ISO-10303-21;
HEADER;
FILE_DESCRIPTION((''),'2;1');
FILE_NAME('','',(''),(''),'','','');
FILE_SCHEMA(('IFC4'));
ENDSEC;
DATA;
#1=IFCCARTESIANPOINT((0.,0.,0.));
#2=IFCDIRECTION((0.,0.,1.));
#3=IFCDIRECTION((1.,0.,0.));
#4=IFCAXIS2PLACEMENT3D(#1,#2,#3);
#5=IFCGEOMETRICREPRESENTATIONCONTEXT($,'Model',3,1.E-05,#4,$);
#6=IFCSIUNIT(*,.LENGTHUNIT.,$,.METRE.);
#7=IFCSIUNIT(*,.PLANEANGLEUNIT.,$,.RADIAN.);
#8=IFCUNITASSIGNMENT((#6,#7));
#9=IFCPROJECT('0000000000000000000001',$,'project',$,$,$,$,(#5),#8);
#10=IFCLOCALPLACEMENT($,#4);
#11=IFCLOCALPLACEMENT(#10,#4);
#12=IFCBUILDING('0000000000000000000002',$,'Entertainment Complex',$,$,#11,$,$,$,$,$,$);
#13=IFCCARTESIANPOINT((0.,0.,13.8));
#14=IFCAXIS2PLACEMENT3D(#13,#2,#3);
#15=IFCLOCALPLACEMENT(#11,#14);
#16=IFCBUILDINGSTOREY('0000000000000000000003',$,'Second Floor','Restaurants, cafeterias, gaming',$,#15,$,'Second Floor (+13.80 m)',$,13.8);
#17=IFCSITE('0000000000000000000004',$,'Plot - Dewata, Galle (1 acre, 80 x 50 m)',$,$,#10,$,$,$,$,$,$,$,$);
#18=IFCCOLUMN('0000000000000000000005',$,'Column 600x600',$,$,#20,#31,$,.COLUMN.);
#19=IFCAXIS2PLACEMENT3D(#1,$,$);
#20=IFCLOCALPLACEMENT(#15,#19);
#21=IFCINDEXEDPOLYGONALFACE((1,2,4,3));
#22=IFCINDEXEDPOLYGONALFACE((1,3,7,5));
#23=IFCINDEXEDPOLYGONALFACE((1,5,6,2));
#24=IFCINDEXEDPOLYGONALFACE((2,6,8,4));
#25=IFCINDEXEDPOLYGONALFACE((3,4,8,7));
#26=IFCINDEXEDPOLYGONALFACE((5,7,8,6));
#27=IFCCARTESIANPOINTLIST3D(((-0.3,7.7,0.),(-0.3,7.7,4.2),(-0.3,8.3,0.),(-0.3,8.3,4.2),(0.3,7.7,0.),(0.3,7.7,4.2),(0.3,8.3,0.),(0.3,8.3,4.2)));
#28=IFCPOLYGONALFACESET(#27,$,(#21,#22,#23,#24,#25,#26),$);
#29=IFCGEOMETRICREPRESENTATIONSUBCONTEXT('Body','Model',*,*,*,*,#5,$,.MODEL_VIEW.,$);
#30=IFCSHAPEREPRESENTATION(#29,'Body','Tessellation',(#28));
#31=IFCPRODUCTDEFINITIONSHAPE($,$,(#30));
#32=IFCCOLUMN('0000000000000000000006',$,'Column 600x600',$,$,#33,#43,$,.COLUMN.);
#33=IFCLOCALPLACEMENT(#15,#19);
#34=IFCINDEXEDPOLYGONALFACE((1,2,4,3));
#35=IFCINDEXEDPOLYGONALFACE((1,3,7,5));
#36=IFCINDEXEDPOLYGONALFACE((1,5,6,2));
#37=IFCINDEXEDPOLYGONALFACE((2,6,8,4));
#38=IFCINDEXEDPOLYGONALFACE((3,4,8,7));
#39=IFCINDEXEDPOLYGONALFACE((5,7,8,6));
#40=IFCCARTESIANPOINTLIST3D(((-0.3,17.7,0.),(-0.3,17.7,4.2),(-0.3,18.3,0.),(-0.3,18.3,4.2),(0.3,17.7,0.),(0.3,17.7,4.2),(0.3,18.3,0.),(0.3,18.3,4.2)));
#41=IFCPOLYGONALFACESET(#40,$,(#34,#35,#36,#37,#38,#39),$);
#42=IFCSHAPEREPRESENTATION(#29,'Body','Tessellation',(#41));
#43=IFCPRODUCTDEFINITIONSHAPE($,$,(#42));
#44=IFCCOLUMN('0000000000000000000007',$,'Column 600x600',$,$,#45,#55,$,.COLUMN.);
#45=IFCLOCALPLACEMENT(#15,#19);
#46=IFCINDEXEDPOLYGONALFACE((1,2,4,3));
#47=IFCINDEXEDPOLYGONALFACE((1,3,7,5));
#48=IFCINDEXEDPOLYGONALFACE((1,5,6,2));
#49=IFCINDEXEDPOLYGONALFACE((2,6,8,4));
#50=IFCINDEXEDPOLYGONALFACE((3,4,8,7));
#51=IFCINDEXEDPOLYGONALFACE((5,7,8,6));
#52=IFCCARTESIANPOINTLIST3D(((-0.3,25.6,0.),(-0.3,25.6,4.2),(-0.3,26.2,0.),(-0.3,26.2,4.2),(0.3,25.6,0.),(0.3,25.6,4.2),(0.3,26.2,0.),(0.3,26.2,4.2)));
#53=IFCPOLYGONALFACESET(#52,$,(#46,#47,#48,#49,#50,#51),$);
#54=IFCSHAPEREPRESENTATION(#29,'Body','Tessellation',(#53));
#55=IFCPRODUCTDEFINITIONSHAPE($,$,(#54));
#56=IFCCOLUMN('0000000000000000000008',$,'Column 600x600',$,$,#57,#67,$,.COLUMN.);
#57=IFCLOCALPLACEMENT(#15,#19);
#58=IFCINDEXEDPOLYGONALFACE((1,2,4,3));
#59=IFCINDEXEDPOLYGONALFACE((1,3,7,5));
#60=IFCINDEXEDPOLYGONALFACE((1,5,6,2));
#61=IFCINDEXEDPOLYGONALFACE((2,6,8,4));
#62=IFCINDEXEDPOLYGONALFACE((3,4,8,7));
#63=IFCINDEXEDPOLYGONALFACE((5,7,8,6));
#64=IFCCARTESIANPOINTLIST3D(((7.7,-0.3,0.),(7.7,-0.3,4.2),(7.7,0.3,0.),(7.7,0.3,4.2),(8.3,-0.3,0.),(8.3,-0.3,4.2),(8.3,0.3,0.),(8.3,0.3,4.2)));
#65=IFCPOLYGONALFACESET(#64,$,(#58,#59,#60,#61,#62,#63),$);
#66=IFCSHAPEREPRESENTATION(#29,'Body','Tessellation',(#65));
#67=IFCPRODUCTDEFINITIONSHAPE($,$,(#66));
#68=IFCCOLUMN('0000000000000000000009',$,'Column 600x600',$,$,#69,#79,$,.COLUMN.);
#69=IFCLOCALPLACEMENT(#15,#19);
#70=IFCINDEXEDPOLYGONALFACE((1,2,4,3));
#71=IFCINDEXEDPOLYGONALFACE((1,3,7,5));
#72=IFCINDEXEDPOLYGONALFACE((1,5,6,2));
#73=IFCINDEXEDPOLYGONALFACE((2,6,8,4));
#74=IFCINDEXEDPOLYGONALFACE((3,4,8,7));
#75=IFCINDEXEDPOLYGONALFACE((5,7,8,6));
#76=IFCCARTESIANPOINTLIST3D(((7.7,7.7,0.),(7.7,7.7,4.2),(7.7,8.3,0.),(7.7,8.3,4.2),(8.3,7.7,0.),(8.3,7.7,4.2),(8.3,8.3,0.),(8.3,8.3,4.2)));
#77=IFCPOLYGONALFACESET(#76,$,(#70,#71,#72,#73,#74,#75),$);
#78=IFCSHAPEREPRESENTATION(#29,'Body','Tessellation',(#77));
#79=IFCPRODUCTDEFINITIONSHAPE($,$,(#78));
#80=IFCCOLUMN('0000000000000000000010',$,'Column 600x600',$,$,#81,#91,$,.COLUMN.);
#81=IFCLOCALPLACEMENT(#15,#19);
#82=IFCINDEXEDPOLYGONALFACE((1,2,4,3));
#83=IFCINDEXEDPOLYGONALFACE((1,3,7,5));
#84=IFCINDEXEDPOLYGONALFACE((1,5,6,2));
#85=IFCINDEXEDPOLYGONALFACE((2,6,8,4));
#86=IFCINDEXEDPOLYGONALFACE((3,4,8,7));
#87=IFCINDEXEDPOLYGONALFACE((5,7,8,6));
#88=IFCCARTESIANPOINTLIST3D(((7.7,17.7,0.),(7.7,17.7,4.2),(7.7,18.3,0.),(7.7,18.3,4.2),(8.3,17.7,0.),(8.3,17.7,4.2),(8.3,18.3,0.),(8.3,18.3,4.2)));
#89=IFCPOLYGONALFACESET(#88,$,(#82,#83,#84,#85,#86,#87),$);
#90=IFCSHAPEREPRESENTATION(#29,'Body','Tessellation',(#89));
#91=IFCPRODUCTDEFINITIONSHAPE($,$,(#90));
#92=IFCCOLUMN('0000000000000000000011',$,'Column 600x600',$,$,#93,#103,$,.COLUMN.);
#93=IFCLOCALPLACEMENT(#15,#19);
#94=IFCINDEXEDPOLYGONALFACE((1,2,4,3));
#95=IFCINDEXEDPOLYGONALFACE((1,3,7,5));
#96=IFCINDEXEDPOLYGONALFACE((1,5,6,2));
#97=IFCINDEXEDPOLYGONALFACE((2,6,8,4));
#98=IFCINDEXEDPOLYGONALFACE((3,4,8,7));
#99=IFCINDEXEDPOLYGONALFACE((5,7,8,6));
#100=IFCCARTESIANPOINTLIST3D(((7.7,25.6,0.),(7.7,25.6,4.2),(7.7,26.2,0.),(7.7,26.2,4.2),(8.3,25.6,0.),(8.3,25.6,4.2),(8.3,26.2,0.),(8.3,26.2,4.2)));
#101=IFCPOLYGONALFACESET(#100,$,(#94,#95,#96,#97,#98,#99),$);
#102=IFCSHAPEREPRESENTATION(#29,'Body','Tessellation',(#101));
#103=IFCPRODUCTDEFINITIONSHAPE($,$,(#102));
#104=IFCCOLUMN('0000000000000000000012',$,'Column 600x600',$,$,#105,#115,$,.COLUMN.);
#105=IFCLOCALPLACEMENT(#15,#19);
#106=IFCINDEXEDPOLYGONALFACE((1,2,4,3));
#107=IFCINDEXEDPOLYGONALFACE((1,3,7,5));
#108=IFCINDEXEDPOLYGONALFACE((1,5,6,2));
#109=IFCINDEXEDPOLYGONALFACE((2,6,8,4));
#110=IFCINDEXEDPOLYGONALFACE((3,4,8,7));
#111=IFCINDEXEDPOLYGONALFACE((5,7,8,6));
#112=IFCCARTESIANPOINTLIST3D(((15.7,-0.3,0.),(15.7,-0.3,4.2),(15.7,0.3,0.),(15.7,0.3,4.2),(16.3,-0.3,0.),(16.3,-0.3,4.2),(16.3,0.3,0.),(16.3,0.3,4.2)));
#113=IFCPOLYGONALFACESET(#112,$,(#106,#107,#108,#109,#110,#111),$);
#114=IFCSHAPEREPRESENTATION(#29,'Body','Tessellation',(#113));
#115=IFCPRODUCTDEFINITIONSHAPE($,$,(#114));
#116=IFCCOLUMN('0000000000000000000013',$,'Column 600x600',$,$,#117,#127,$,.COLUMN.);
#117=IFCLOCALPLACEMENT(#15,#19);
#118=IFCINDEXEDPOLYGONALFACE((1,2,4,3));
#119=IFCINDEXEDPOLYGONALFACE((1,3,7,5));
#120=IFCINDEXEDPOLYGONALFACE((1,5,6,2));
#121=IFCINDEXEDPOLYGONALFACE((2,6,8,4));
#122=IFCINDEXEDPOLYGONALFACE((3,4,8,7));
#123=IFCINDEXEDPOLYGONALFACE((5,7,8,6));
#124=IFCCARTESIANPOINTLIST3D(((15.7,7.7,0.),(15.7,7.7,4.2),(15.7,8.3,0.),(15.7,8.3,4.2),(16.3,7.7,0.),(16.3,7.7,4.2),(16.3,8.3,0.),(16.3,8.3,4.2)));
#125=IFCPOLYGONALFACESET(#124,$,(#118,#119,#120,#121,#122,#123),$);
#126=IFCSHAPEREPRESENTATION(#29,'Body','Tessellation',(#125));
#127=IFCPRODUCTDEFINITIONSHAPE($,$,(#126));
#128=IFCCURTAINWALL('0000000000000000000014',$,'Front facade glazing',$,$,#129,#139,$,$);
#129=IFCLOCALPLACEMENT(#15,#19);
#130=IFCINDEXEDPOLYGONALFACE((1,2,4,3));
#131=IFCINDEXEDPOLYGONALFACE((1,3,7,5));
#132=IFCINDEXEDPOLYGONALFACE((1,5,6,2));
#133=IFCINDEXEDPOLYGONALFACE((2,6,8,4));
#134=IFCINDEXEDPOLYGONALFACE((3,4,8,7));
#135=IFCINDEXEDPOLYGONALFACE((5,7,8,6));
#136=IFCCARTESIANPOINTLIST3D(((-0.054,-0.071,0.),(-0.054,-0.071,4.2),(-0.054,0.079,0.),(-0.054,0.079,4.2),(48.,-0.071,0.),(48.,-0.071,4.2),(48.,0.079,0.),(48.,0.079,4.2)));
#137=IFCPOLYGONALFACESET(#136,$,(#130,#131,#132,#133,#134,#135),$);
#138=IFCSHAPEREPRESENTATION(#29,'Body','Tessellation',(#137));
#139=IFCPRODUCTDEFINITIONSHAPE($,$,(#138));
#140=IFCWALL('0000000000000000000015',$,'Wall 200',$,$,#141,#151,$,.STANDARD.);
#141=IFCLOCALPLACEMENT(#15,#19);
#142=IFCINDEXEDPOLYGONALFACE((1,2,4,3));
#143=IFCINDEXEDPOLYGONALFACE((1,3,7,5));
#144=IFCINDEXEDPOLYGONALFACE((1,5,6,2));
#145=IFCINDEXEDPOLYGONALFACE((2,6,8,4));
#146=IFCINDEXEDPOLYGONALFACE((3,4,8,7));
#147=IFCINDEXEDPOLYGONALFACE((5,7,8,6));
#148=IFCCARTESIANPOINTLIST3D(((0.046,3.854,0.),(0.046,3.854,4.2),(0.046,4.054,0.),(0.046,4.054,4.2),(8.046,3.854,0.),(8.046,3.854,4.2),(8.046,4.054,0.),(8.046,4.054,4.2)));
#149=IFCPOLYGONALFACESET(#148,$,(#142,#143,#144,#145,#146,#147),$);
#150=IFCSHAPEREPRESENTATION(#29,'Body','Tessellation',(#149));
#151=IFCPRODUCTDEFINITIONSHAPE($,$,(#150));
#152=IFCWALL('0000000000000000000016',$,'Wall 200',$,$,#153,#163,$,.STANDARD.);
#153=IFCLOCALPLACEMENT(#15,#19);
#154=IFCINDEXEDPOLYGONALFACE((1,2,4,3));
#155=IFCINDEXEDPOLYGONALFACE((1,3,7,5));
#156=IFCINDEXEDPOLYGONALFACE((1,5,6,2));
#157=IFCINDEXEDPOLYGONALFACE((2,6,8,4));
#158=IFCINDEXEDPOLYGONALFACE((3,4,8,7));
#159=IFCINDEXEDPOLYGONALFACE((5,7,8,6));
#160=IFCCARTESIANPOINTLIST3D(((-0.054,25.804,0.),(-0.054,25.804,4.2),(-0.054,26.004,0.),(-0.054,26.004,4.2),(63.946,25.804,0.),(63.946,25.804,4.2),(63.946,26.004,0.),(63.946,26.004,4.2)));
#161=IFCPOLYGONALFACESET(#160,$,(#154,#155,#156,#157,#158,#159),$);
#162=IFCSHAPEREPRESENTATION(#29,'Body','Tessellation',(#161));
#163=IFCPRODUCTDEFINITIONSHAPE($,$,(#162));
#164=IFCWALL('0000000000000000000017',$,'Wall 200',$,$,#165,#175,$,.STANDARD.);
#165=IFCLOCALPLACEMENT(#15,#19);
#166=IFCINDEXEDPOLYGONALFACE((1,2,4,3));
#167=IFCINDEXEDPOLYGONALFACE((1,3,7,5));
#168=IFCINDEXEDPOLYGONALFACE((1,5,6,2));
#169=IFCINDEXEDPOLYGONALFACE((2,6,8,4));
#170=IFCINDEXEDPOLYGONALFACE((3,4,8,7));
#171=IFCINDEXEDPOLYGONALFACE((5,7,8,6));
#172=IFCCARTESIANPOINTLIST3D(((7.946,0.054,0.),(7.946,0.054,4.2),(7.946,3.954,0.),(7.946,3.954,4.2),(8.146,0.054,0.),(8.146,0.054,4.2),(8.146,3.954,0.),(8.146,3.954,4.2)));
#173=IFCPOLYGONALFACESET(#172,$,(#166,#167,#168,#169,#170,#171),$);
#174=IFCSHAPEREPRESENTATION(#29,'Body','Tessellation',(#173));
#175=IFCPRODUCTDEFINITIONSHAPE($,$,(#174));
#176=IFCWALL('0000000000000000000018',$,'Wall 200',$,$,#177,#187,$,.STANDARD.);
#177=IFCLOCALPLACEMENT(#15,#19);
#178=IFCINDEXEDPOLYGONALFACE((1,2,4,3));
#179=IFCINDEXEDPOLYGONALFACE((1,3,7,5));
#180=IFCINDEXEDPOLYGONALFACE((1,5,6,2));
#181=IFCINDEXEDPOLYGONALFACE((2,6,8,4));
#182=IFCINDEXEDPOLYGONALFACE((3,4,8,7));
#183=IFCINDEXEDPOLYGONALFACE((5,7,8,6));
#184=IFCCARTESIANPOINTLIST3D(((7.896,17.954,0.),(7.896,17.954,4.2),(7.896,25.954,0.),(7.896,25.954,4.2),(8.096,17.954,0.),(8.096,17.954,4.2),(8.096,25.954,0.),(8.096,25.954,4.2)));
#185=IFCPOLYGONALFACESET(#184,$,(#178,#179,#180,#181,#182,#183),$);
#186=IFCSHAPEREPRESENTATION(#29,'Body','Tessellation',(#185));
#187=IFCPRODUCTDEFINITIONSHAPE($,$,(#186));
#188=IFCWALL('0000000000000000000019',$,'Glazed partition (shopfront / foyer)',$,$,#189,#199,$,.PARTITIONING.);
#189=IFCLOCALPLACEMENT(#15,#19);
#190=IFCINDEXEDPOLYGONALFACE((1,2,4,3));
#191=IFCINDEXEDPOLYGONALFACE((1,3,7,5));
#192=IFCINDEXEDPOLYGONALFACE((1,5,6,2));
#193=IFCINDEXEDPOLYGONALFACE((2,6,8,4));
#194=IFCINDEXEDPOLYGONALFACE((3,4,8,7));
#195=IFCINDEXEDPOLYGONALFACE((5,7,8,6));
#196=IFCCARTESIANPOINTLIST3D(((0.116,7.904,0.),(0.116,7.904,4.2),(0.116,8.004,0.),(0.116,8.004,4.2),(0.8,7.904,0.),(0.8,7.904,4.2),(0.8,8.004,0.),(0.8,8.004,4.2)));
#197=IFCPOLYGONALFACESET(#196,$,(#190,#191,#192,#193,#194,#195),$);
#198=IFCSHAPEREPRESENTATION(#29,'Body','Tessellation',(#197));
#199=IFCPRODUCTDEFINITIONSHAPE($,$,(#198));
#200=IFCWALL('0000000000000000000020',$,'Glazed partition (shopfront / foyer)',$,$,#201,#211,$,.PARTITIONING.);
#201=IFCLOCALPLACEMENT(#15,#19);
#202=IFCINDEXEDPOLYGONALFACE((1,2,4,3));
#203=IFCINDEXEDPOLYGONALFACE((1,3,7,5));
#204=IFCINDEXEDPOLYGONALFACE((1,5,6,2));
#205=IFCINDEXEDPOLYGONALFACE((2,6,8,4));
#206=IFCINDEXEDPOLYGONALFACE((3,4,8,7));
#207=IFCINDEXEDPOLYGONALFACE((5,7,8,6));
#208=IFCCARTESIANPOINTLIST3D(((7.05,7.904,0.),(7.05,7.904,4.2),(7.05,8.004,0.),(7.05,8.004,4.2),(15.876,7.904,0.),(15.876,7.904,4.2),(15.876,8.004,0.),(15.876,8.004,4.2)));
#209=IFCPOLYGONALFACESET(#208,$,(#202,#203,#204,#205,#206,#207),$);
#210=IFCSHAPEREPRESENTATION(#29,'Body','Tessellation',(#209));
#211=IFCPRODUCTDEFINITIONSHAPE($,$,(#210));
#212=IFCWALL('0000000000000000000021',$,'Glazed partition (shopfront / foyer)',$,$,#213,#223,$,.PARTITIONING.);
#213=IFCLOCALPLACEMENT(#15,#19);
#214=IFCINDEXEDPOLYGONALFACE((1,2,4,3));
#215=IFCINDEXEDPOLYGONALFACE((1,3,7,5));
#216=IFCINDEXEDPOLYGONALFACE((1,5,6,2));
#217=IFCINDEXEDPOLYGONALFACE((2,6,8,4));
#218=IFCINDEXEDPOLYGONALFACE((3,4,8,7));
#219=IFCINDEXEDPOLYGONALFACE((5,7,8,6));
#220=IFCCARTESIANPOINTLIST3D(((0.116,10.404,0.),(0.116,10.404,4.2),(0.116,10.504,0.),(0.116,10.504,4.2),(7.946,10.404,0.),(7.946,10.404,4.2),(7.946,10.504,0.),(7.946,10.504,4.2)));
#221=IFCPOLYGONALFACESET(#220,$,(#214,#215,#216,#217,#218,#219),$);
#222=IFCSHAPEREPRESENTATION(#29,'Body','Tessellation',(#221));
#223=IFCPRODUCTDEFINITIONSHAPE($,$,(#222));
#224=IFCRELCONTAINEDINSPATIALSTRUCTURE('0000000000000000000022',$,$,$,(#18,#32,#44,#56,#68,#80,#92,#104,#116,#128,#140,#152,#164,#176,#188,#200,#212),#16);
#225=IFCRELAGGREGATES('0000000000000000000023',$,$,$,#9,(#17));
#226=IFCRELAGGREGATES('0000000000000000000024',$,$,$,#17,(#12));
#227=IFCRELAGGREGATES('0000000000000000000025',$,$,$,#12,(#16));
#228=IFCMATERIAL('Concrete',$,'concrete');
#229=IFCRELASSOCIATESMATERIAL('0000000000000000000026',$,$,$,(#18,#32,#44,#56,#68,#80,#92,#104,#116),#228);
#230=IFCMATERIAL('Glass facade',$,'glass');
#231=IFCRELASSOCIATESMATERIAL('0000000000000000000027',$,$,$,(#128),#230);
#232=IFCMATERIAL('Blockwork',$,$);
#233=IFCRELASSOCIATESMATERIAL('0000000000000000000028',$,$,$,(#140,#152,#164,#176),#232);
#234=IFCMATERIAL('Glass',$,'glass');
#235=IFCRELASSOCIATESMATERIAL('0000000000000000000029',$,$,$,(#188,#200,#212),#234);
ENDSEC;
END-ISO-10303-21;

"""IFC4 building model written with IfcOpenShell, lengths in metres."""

from ifc_helpers import new_model, si_unit, frame, origin_with_axes, place, context, subcontext, project, spatial, polyline, outline, extrude, material, element, save


model = new_model("IFC4")

# Units and contexts
model_context = context("Model", 3, precision=1e-05, world=origin_with_axes())
body_context = subcontext(model_context, "Body", "Model", "MODEL_VIEW")
ifc_project = project(units=[si_unit("LENGTHUNIT", "METRE"), si_unit("PLANEANGLEUNIT", "RADIAN")], contexts=[model_context])

# Site, building, storey
site_placement = place(None, origin_with_axes())
site = spatial("IfcSite", under=ifc_project, at=site_placement, Name="Plot - Dewata, Galle (1 acre, 80 x 50 m)")
building_placement = place(site_placement, origin_with_axes())
building = spatial("IfcBuilding", under=site, at=building_placement, Name="Entertainment Complex")
storey_placement = place(building_placement, frame((0.0, 0.0, 13.8), z_axis=(0.0, 0.0, 1.0), x_axis=(1.0, 0.0, 0.0)))
storey = spatial("IfcBuildingStorey", under=building, at=storey_placement, Name="Second Floor", Description="Restaurants, cafeterias, gaming", LongName="Second Floor (+13.80 m)", Elevation=13.8)

# Columns
ifc_material_1 = material(Name="Concrete", Category="concrete")
for number, where, z_axis, x_axis, name in (
    (1, (0.0, 8.0, 0.0), (0.0, 0.0, 1.0), (1.0, 0.0, 0.0), "Column 600x600"),
    (2, (0.0, 18.0, 0.0), (0.0, 0.0, 1.0), (1.0, 0.0, 0.0), "Column 600x600"),
    (3, (0.0, 25.9, 0.0), (0.0, 0.0, 1.0), (1.0, 0.0, 0.0), "Column 600x600"),
    (4, (8.0, 0.0, 0.0), (0.0, 0.0, 1.0), (1.0, 0.0, 0.0), "Column 600x600"),
    (5, (8.0, 8.0, 0.0), (0.0, 0.0, 1.0), (1.0, 0.0, 0.0), "Column 600x600"),
    (6, (8.0, 18.0, 0.0), (0.0, 0.0, 1.0), (1.0, 0.0, 0.0), "Column 600x600"),
    (7, (8.0, 25.9, 0.0), (0.0, 0.0, 1.0), (1.0, 0.0, 0.0), "Column 600x600"),
    (8, (16.0, 0.0, 0.0), (0.0, 0.0, 1.0), (1.0, 0.0, 0.0), "Column 600x600"),
    (9, (16.0, 8.0, 0.0), (0.0, 0.0, 1.0), (1.0, 0.0, 0.0), "Column 600x600"),
):
    element("IfcColumn", number, at=place(storey_placement, frame(where, z_axis=z_axis, x_axis=x_axis)), inside=storey, material=ifc_material_1, Name=name, PredefinedType="COLUMN", context=body_context, shape_type="SweptSolid", body=[
        extrude(outline(polyline([(-0.3, -0.3), (0.3, -0.3), (0.3, 0.3), (-0.3, 0.3), (-0.3, -0.3)])), origin_with_axes(), (0.0, 0.0, 1.0), 4.2),
    ])

# Curtain wall
ifc_material_2 = material(Name="Glass facade", Category="glass")
curtain_wall_placement = place(storey_placement, frame((-0.054, 0.004, 0.0), z_axis=(0.0, 0.0, 1.0), x_axis=(1.0, 0.0, 0.0)))
element("IfcCurtainWall", 10, at=curtain_wall_placement, inside=storey, material=ifc_material_2, Name="Front facade glazing", context=body_context, shape_type="SweptSolid", body=[
    extrude(outline(polyline([(0.0, -0.075), (48.054, -0.075), (48.054, 0.075), (0.0, 0.075), (0.0, -0.075)])), origin_with_axes(), (0.0, 0.0, 1.0), 4.2),
])

# Walls
ifc_material_3 = material(Name="Blockwork")
wall_1_placement = place(storey_placement, frame((0.046, 3.954, 0.0), z_axis=(0.0, 0.0, 1.0), x_axis=(1.0, 0.0, 0.0)))
element("IfcWall", 11, at=wall_1_placement, inside=storey, material=ifc_material_3, Name="Wall 200", PredefinedType="STANDARD", context=body_context, shape_type="SweptSolid", body=[
    extrude(outline(polyline([(0.0, -0.1), (8.0, -0.1), (8.0, 0.1), (0.0, 0.1), (0.0, -0.1)])), origin_with_axes(), (0.0, 0.0, 1.0), 4.2),
])
wall_2_placement = place(storey_placement, frame((-0.054, 25.904, 0.0), z_axis=(0.0, 0.0, 1.0), x_axis=(1.0, 0.0, 0.0)))
element("IfcWall", 12, at=wall_2_placement, inside=storey, material=ifc_material_3, Name="Wall 200", PredefinedType="STANDARD", context=body_context, shape_type="SweptSolid", body=[
    extrude(outline(polyline([(0.0, -0.1), (64.0, -0.1), (64.0, 0.1), (0.0, 0.1), (0.0, -0.1)])), origin_with_axes(), (0.0, 0.0, 1.0), 4.2),
])
wall_3_placement = place(storey_placement, frame((8.046, 0.054, 0.0), z_axis=(0.0, 0.0, 1.0), x_axis=(0.0, 1.0, 0.0)))
element("IfcWall", 13, at=wall_3_placement, inside=storey, material=ifc_material_3, Name="Wall 200", PredefinedType="STANDARD", context=body_context, shape_type="SweptSolid", body=[
    extrude(outline(polyline([(0.0, -0.1), (3.9, -0.1), (3.9, 0.1), (0.0, 0.1), (0.0, -0.1)])), origin_with_axes(), (0.0, 0.0, 1.0), 4.2),
])
wall_4_placement = place(storey_placement, frame((7.996, 17.954, 0.0), z_axis=(0.0, 0.0, 1.0), x_axis=(0.0, 1.0, 0.0)))
element("IfcWall", 14, at=wall_4_placement, inside=storey, material=ifc_material_3, Name="Wall 200", PredefinedType="STANDARD", context=body_context, shape_type="SweptSolid", body=[
    extrude(outline(polyline([(0.0, -0.1), (8.0, -0.1), (8.0, 0.1), (0.0, 0.1), (0.0, -0.1)])), origin_with_axes(), (0.0, 0.0, 1.0), 4.2),
])
ifc_material_4 = material(Name="Glass", Category="glass")
wall_5_placement = place(storey_placement, frame((0.116, 7.954, 0.0), z_axis=(0.0, 0.0, 1.0), x_axis=(1.0, 0.0, 0.0)))
element("IfcWall", 15, at=wall_5_placement, inside=storey, material=ifc_material_4, Name="Glazed partition (shopfront / foyer)", PredefinedType="PARTITIONING", context=body_context, shape_type="SweptSolid", body=[
    extrude(outline(polyline([(0.0, -0.05), (0.684, -0.05), (0.684, 0.05), (0.0, 0.05), (0.0, -0.05)])), origin_with_axes(), (0.0, 0.0, 1.0), 4.2),
])
wall_6_placement = place(storey_placement, frame((7.05, 7.954, 0.0), z_axis=(0.0, 0.0, 1.0), x_axis=(1.0, 0.0, 0.0)))
element("IfcWall", 16, at=wall_6_placement, inside=storey, material=ifc_material_4, Name="Glazed partition (shopfront / foyer)", PredefinedType="PARTITIONING", context=body_context, shape_type="SweptSolid", body=[
    extrude(outline(polyline([(0.0, -0.05), (8.826, -0.05), (8.826, 0.05), (0.0, 0.05), (0.0, -0.05)])), origin_with_axes(), (0.0, 0.0, 1.0), 4.2),
])
wall_7_placement = place(storey_placement, frame((0.116, 10.454, 0.0), z_axis=(0.0, 0.0, 1.0), x_axis=(1.0, 0.0, 0.0)))
element("IfcWall", 17, at=wall_7_placement, inside=storey, material=ifc_material_4, Name="Glazed partition (shopfront / foyer)", PredefinedType="PARTITIONING", context=body_context, shape_type="SweptSolid", body=[
    extrude(outline(polyline([(0.0, -0.05), (7.83, -0.05), (7.83, 0.05), (0.0, 0.05), (0.0, -0.05)])), origin_with_axes(), (0.0, 0.0, 1.0), 4.2),
])

save(model, "model.ifc")
